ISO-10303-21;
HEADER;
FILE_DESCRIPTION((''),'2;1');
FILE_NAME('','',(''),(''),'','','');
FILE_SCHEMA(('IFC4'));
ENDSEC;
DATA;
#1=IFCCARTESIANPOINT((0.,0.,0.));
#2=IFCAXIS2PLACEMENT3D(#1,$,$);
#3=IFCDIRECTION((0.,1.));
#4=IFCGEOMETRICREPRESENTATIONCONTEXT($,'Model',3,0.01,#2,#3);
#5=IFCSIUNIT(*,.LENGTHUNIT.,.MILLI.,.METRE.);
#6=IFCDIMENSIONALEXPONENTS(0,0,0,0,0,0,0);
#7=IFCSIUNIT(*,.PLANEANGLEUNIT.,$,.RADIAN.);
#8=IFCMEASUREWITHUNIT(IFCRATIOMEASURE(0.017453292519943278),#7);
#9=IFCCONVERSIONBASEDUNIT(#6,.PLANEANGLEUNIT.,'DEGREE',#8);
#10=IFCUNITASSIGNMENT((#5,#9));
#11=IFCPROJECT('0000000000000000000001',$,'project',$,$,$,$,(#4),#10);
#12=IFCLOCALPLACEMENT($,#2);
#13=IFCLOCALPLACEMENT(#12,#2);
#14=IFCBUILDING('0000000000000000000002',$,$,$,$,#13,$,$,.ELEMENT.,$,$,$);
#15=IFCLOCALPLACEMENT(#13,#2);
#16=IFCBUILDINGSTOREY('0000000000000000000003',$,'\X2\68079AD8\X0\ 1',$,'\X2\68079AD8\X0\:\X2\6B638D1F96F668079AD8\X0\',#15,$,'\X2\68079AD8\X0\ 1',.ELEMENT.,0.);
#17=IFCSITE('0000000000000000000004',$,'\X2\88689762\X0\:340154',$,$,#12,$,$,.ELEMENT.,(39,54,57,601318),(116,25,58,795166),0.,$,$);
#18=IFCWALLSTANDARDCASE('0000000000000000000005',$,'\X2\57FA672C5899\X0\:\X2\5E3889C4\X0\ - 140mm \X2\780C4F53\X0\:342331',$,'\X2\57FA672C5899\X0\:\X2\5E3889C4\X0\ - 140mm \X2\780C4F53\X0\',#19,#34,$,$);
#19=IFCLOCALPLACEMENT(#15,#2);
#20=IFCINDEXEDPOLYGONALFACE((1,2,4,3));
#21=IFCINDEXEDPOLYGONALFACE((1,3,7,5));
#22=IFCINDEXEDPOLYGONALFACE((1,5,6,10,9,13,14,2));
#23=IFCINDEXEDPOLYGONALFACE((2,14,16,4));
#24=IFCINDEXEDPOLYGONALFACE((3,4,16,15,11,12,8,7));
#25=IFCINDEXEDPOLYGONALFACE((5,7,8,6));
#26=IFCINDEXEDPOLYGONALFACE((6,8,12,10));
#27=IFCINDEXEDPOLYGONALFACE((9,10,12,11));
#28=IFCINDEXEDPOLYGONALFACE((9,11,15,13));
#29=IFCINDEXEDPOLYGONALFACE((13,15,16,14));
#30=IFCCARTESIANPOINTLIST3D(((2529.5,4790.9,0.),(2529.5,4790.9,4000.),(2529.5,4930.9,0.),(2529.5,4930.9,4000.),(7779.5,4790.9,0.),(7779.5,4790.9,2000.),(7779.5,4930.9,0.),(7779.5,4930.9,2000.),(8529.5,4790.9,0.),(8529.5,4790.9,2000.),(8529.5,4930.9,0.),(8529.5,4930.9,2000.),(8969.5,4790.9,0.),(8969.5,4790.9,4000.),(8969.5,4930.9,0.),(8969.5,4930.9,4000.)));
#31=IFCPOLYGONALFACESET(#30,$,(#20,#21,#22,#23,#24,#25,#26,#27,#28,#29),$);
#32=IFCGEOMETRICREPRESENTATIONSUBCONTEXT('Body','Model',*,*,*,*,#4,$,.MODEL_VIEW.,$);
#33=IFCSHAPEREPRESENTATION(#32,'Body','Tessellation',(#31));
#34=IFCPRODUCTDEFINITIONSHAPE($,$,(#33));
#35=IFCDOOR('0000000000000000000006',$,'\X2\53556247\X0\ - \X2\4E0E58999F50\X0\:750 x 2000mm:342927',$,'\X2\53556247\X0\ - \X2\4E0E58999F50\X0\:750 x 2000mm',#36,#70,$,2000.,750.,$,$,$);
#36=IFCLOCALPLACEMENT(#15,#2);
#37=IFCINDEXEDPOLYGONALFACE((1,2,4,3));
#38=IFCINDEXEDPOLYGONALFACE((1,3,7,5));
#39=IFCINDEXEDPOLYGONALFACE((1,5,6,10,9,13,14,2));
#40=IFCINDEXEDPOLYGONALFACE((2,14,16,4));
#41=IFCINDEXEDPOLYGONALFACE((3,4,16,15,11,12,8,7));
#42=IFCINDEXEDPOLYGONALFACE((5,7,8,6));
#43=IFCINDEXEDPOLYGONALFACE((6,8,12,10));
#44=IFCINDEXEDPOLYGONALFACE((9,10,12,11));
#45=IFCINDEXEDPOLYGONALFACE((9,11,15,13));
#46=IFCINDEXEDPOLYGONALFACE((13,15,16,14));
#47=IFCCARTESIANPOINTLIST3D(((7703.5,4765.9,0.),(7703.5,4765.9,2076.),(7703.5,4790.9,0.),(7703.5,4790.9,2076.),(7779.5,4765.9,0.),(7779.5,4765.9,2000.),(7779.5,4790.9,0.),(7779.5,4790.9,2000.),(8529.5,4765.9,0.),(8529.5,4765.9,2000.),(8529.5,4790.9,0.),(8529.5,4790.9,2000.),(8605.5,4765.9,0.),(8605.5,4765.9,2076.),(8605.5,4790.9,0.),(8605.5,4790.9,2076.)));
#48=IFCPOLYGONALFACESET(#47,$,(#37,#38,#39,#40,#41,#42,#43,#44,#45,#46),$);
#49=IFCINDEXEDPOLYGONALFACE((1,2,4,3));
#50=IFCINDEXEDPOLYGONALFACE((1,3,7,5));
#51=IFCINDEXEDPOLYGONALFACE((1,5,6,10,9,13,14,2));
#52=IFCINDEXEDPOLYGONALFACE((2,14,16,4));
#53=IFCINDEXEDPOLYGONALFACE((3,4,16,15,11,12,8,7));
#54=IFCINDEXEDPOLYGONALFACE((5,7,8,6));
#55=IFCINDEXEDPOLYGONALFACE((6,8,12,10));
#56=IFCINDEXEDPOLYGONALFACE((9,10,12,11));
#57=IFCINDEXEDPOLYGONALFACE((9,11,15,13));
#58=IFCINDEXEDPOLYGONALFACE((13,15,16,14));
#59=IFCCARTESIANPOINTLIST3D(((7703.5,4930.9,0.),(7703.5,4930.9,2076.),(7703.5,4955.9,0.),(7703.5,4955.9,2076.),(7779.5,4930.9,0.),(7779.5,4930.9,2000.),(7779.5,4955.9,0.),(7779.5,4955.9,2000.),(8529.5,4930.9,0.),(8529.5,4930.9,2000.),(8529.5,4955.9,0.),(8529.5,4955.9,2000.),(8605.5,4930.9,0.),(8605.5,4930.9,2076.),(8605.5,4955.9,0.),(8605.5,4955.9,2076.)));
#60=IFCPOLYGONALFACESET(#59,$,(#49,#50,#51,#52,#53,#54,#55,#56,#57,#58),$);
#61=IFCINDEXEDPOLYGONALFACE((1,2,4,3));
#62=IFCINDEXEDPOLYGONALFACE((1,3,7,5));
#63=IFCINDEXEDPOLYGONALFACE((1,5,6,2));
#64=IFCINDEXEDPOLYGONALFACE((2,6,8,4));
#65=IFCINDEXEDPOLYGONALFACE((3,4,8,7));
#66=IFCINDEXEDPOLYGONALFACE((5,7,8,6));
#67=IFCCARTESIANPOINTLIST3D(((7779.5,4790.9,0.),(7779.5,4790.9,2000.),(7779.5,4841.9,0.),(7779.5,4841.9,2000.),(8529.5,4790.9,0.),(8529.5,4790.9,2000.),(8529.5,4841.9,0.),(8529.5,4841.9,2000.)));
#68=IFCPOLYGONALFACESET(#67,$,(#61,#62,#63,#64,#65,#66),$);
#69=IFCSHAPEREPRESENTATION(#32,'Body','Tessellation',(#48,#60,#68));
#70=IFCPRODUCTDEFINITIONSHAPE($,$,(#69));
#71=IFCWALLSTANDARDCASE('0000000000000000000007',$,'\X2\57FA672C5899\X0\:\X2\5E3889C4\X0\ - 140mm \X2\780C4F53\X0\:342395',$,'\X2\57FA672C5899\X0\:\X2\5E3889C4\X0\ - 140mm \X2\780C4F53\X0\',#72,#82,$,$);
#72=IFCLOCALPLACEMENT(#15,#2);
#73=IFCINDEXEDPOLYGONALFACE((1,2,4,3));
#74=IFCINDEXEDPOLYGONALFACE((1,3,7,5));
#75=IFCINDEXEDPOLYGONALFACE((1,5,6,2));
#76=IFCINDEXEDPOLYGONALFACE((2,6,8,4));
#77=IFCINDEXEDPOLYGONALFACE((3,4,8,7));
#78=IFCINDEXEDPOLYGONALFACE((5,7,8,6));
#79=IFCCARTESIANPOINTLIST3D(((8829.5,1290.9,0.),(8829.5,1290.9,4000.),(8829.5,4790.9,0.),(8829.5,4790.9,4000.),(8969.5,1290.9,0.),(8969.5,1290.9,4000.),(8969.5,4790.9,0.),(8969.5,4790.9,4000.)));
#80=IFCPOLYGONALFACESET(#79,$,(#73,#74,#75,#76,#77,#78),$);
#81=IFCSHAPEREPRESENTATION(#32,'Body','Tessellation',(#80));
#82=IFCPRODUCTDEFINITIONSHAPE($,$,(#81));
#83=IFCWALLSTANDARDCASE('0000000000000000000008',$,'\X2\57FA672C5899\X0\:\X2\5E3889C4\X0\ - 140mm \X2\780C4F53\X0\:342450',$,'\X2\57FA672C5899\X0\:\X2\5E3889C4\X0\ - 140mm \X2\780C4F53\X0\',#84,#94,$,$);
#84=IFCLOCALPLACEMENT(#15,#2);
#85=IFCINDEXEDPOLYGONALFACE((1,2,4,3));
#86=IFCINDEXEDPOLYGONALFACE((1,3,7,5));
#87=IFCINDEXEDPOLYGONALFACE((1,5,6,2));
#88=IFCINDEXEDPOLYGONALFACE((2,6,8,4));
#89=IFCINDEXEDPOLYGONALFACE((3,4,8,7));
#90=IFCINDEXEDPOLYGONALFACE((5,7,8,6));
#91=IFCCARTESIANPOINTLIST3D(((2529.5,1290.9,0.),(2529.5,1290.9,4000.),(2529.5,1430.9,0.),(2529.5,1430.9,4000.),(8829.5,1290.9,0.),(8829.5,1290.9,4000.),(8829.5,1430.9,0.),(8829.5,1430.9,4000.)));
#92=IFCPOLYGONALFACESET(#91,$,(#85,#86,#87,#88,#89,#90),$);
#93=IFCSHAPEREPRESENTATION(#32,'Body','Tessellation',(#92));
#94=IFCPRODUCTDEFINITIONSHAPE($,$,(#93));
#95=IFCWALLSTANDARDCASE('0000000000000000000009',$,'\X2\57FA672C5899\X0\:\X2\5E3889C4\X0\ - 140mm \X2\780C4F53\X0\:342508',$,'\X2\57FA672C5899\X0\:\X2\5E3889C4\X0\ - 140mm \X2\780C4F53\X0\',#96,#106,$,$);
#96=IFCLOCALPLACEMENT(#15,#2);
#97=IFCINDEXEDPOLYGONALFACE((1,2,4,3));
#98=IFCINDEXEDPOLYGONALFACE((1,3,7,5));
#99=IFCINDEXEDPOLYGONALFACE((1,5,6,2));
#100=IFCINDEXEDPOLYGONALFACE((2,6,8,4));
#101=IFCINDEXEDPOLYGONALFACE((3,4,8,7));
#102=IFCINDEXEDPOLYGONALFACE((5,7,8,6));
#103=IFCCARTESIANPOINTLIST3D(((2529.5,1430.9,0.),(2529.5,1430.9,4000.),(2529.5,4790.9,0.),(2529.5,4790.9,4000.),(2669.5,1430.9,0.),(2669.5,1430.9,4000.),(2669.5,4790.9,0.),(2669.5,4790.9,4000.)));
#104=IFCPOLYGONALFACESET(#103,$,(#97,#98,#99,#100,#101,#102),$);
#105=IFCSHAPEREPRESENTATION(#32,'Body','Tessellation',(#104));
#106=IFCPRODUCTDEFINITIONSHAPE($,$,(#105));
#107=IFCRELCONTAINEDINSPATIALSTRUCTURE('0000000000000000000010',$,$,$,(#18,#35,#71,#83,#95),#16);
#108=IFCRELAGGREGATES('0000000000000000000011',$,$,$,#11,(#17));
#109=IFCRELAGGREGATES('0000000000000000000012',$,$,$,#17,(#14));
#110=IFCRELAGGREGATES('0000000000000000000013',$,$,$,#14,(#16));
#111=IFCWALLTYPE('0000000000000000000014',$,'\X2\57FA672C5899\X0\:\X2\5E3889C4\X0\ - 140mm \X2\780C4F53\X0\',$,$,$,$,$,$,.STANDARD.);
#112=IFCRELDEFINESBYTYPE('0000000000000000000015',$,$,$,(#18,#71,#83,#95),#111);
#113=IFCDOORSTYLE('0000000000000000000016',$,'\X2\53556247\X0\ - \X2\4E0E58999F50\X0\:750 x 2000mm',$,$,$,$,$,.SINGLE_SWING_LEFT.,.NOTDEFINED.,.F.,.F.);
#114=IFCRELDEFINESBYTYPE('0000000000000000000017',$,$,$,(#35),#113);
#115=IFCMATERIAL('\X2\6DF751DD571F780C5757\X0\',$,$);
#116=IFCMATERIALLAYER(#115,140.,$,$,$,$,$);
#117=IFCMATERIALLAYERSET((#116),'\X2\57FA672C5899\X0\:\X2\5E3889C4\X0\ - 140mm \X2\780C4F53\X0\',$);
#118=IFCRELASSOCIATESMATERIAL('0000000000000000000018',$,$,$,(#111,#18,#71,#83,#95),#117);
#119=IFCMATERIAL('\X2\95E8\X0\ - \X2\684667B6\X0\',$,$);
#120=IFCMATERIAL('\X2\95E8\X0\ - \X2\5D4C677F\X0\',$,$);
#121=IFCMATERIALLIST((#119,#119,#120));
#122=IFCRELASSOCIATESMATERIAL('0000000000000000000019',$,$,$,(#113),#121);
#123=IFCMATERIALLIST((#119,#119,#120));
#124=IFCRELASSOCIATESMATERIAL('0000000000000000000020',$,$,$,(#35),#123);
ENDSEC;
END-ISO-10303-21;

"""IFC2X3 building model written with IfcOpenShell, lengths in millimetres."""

from ifc_helpers import new_model, entity, si_unit, converted_unit, direction, frame, frame_2d, origin, place, context, subcontext, project, spatial, polyline, rectangle, outline, extrude, source, transform, mapped, material, material_list, layer, layer_set, layer_usage, type_object, type_shapes, element, fill, save


model = new_model("IFC2X3")

# Units and contexts
model_context = context("Model", 3, precision=0.01, world=origin(), true_north=direction((0.0, 1.0)))
body_context = subcontext(model_context, "Body", "Model", "MODEL_VIEW")
ifc_project = project(units=[si_unit("LENGTHUNIT", "METRE", prefix="MILLI"), converted_unit("PLANEANGLEUNIT", "DEGREE", entity("IfcRatioMeasure", 0.017453292519943278), si_unit("PLANEANGLEUNIT", "RADIAN"), dimensions=[0, 0, 0, 0, 0, 0, 0])], contexts=[model_context])

# Site, building, storey
site_placement = place(None, origin())
site = spatial("IfcSite", under=ifc_project, at=site_placement, Name="表面:340154", CompositionType="ELEMENT", RefLatitude=(39, 54, 57, 601318), RefLongitude=(116, 25, 58, 795166), RefElevation=0.0)
building_placement = place(site_placement, origin())
building = spatial("IfcBuilding", under=site, at=building_placement, CompositionType="ELEMENT")
storey_placement = place(building_placement, origin())
storey = spatial("IfcBuildingStorey", under=building, at=storey_placement, Name="标高 1", ObjectType="标高:正负零标高", LongName="标高 1", CompositionType="ELEMENT", Elevation=0.0)

# Shared definitions
ifc_material_1 = material(Name="门 - 框架")
ifc_material_2 = material(Name="门 - 嵌板")

# Wall, opening, door
ifc_material_3 = material(Name="混凝土砌块")
ifc_layer_1 = layer(ifc_material_3, 140.0)
ifc_layer_set_1 = layer_set([ifc_layer_1], Name="基本墙:常规 - 140mm 砌体")
ifc_layer_usage_1 = layer_usage(ifc_layer_set_1, "AXIS2", "NEGATIVE", 70.0)
wall_type_1 = type_object("IfcWallType", Name="基本墙:常规 - 140mm 砌体", PredefinedType="STANDARD", material=ifc_layer_set_1)
wall_1_placement = place(storey_placement, frame((2529.5, 4860.9, 0.0)))
wall_1 = element("IfcWallStandardCase", 1, at=wall_1_placement, inside=storey, type_object=wall_type_1, material=ifc_layer_usage_1, Name="基本墙:常规 - 140mm 砌体:342331", ObjectType="基本墙:常规 - 140mm 砌体", context=body_context, shape_type="SweptSolid", body=[
    extrude(rectangle(XDim=6440.0, YDim=140.0, at=frame_2d((3220.0, 0.0), x_axis=(1.0, 0.0))), origin(), (0.0, 0.0, 1.0), 4000.0),
])
opening_1_placement = place(wall_1_placement, frame((6000.0, 70.0, 0.0)))
opening_1 = element("IfcOpeningElement", 2, at=opening_1_placement, cuts=wall_1, ObjectType="Opening", context=body_context, shape_type="SweptSolid", body=[
    extrude(rectangle(XDim=750.0, YDim=2000.0, at=frame_2d((1000.0, 375.0), x_axis=(0.0, -1.0))), frame((0.0, 0.0, 0.0), z_axis=(0.0, -1.0, 0.0), x_axis=(0.0, 0.0, 1.0)), (0.0, 0.0, 1.0), 140.0),
])
ifc_material_list_1 = material_list([ifc_material_1, ifc_material_1, ifc_material_2])
ifc_material_list_2 = material_list([ifc_material_1, ifc_material_1, ifc_material_2])
door_style_1 = type_object("IfcDoorStyle", Name="单扇 - 与墙齐:750 x 2000mm", ConstructionType="NOTDEFINED", OperationType="SINGLE_SWING_LEFT", ParameterTakesPrecedence=False, Sizeable=False, material=ifc_material_list_2)
shared_shape_1 = source(origin(), body_context, "Body", "SweptSolid", [
    extrude(outline(polyline([(-451.0, -1057.0), (451.0, -1057.0), (451.0, 1019.0), (375.0, 1019.0), (375.0, -981.0), (-375.0, -981.0), (-375.0, 1019.0), (-451.0, 1019.0), (-451.0, -1057.0)])), frame((375.0, 165.0, 1019.0), z_axis=(0.0, -1.0, 0.0), x_axis=(-1.0, 0.0, 0.0)), (0.0, 0.0, 1.0), 25.0),
    extrude(outline(polyline([(-1057.0, -451.0), (1019.0, -451.0), (1019.0, -375.0), (-981.0, -375.0), (-981.0, 375.0), (1019.0, 375.0), (1019.0, 451.0), (-1057.0, 451.0), (-1057.0, -451.0)])), frame((375.0, 0.0, 1019.0), z_axis=(0.0, -1.0, 0.0), x_axis=(0.0, 0.0, -1.0)), (0.0, 0.0, 1.0), 25.0),
    extrude(rectangle(XDim=750.0, YDim=51.0, at=frame_2d((0.0, 0.0), x_axis=(1.0, 0.0))), frame((375.0, 114.5, 0.0)), (0.0, 0.0, 1.0), 2000.0),
])
type_shapes(door_style_1, [shared_shape_1])
door_1_placement = place(opening_1_placement, frame((0.0, 0.0, 0.0), z_axis=(0.0, 0.0, 1.0), x_axis=(-1.0, 0.0, 0.0)))
door_1 = element("IfcDoor", 3, at=door_1_placement, inside=storey, type_object=door_style_1, material=ifc_material_list_1, Name="单扇 - 与墙齐:750 x 2000mm:342927", ObjectType="单扇 - 与墙齐:750 x 2000mm", OverallHeight=2000.0, OverallWidth=750.0, context=body_context, shape_type="MappedRepresentation", body=[
    mapped(shared_shape_1, transform((0.0, 0.0, 0.0), scale=1.0)),
])
fill(opening_1, door_1)

# Walls
ifc_layer_usage_2 = layer_usage(ifc_layer_set_1, "AXIS2", "NEGATIVE", 70.0)
wall_2_placement = place(storey_placement, frame((8899.5, 4790.9, 0.0), z_axis=(0.0, 0.0, 1.0), x_axis=(0.0, -1.0, 0.0)))
element("IfcWallStandardCase", 4, at=wall_2_placement, inside=storey, type_object=wall_type_1, material=ifc_layer_usage_2, Name="基本墙:常规 - 140mm 砌体:342395", ObjectType="基本墙:常规 - 140mm 砌体", context=body_context, shape_type="SweptSolid", body=[
    extrude(rectangle(XDim=3500.0, YDim=140.0, at=frame_2d((1750.0, 0.0), x_axis=(-1.0, 0.0))), origin(), (0.0, 0.0, 1.0), 4000.0),
])
ifc_layer_usage_3 = layer_usage(ifc_layer_set_1, "AXIS2", "NEGATIVE", 70.0)
wall_3_placement = place(storey_placement, frame((8829.5, 1360.9, 0.0), z_axis=(0.0, 0.0, 1.0), x_axis=(-1.0, 0.0, 0.0)))
element("IfcWallStandardCase", 5, at=wall_3_placement, inside=storey, type_object=wall_type_1, material=ifc_layer_usage_3, Name="基本墙:常规 - 140mm 砌体:342450", ObjectType="基本墙:常规 - 140mm 砌体", context=body_context, shape_type="SweptSolid", body=[
    extrude(rectangle(XDim=6300.0, YDim=140.0, at=frame_2d((3150.0, 0.0), x_axis=(-1.0, 0.0))), origin(), (0.0, 0.0, 1.0), 4000.0),
])
ifc_layer_usage_4 = layer_usage(ifc_layer_set_1, "AXIS2", "NEGATIVE", 70.0)
wall_4_placement = place(storey_placement, frame((2599.5, 1430.9, 0.0), z_axis=(0.0, 0.0, 1.0), x_axis=(0.0, 1.0, 0.0)))
element("IfcWallStandardCase", 6, at=wall_4_placement, inside=storey, type_object=wall_type_1, material=ifc_layer_usage_4, Name="基本墙:常规 - 140mm 砌体:342508", ObjectType="基本墙:常规 - 140mm 砌体", context=body_context, shape_type="SweptSolid", body=[
    extrude(rectangle(XDim=3360.0, YDim=140.0, at=frame_2d((1680.0, 0.0), x_axis=(-1.0, 0.0))), origin(), (0.0, 0.0, 1.0), 4000.0),
])

save(model, "model.ifc")
